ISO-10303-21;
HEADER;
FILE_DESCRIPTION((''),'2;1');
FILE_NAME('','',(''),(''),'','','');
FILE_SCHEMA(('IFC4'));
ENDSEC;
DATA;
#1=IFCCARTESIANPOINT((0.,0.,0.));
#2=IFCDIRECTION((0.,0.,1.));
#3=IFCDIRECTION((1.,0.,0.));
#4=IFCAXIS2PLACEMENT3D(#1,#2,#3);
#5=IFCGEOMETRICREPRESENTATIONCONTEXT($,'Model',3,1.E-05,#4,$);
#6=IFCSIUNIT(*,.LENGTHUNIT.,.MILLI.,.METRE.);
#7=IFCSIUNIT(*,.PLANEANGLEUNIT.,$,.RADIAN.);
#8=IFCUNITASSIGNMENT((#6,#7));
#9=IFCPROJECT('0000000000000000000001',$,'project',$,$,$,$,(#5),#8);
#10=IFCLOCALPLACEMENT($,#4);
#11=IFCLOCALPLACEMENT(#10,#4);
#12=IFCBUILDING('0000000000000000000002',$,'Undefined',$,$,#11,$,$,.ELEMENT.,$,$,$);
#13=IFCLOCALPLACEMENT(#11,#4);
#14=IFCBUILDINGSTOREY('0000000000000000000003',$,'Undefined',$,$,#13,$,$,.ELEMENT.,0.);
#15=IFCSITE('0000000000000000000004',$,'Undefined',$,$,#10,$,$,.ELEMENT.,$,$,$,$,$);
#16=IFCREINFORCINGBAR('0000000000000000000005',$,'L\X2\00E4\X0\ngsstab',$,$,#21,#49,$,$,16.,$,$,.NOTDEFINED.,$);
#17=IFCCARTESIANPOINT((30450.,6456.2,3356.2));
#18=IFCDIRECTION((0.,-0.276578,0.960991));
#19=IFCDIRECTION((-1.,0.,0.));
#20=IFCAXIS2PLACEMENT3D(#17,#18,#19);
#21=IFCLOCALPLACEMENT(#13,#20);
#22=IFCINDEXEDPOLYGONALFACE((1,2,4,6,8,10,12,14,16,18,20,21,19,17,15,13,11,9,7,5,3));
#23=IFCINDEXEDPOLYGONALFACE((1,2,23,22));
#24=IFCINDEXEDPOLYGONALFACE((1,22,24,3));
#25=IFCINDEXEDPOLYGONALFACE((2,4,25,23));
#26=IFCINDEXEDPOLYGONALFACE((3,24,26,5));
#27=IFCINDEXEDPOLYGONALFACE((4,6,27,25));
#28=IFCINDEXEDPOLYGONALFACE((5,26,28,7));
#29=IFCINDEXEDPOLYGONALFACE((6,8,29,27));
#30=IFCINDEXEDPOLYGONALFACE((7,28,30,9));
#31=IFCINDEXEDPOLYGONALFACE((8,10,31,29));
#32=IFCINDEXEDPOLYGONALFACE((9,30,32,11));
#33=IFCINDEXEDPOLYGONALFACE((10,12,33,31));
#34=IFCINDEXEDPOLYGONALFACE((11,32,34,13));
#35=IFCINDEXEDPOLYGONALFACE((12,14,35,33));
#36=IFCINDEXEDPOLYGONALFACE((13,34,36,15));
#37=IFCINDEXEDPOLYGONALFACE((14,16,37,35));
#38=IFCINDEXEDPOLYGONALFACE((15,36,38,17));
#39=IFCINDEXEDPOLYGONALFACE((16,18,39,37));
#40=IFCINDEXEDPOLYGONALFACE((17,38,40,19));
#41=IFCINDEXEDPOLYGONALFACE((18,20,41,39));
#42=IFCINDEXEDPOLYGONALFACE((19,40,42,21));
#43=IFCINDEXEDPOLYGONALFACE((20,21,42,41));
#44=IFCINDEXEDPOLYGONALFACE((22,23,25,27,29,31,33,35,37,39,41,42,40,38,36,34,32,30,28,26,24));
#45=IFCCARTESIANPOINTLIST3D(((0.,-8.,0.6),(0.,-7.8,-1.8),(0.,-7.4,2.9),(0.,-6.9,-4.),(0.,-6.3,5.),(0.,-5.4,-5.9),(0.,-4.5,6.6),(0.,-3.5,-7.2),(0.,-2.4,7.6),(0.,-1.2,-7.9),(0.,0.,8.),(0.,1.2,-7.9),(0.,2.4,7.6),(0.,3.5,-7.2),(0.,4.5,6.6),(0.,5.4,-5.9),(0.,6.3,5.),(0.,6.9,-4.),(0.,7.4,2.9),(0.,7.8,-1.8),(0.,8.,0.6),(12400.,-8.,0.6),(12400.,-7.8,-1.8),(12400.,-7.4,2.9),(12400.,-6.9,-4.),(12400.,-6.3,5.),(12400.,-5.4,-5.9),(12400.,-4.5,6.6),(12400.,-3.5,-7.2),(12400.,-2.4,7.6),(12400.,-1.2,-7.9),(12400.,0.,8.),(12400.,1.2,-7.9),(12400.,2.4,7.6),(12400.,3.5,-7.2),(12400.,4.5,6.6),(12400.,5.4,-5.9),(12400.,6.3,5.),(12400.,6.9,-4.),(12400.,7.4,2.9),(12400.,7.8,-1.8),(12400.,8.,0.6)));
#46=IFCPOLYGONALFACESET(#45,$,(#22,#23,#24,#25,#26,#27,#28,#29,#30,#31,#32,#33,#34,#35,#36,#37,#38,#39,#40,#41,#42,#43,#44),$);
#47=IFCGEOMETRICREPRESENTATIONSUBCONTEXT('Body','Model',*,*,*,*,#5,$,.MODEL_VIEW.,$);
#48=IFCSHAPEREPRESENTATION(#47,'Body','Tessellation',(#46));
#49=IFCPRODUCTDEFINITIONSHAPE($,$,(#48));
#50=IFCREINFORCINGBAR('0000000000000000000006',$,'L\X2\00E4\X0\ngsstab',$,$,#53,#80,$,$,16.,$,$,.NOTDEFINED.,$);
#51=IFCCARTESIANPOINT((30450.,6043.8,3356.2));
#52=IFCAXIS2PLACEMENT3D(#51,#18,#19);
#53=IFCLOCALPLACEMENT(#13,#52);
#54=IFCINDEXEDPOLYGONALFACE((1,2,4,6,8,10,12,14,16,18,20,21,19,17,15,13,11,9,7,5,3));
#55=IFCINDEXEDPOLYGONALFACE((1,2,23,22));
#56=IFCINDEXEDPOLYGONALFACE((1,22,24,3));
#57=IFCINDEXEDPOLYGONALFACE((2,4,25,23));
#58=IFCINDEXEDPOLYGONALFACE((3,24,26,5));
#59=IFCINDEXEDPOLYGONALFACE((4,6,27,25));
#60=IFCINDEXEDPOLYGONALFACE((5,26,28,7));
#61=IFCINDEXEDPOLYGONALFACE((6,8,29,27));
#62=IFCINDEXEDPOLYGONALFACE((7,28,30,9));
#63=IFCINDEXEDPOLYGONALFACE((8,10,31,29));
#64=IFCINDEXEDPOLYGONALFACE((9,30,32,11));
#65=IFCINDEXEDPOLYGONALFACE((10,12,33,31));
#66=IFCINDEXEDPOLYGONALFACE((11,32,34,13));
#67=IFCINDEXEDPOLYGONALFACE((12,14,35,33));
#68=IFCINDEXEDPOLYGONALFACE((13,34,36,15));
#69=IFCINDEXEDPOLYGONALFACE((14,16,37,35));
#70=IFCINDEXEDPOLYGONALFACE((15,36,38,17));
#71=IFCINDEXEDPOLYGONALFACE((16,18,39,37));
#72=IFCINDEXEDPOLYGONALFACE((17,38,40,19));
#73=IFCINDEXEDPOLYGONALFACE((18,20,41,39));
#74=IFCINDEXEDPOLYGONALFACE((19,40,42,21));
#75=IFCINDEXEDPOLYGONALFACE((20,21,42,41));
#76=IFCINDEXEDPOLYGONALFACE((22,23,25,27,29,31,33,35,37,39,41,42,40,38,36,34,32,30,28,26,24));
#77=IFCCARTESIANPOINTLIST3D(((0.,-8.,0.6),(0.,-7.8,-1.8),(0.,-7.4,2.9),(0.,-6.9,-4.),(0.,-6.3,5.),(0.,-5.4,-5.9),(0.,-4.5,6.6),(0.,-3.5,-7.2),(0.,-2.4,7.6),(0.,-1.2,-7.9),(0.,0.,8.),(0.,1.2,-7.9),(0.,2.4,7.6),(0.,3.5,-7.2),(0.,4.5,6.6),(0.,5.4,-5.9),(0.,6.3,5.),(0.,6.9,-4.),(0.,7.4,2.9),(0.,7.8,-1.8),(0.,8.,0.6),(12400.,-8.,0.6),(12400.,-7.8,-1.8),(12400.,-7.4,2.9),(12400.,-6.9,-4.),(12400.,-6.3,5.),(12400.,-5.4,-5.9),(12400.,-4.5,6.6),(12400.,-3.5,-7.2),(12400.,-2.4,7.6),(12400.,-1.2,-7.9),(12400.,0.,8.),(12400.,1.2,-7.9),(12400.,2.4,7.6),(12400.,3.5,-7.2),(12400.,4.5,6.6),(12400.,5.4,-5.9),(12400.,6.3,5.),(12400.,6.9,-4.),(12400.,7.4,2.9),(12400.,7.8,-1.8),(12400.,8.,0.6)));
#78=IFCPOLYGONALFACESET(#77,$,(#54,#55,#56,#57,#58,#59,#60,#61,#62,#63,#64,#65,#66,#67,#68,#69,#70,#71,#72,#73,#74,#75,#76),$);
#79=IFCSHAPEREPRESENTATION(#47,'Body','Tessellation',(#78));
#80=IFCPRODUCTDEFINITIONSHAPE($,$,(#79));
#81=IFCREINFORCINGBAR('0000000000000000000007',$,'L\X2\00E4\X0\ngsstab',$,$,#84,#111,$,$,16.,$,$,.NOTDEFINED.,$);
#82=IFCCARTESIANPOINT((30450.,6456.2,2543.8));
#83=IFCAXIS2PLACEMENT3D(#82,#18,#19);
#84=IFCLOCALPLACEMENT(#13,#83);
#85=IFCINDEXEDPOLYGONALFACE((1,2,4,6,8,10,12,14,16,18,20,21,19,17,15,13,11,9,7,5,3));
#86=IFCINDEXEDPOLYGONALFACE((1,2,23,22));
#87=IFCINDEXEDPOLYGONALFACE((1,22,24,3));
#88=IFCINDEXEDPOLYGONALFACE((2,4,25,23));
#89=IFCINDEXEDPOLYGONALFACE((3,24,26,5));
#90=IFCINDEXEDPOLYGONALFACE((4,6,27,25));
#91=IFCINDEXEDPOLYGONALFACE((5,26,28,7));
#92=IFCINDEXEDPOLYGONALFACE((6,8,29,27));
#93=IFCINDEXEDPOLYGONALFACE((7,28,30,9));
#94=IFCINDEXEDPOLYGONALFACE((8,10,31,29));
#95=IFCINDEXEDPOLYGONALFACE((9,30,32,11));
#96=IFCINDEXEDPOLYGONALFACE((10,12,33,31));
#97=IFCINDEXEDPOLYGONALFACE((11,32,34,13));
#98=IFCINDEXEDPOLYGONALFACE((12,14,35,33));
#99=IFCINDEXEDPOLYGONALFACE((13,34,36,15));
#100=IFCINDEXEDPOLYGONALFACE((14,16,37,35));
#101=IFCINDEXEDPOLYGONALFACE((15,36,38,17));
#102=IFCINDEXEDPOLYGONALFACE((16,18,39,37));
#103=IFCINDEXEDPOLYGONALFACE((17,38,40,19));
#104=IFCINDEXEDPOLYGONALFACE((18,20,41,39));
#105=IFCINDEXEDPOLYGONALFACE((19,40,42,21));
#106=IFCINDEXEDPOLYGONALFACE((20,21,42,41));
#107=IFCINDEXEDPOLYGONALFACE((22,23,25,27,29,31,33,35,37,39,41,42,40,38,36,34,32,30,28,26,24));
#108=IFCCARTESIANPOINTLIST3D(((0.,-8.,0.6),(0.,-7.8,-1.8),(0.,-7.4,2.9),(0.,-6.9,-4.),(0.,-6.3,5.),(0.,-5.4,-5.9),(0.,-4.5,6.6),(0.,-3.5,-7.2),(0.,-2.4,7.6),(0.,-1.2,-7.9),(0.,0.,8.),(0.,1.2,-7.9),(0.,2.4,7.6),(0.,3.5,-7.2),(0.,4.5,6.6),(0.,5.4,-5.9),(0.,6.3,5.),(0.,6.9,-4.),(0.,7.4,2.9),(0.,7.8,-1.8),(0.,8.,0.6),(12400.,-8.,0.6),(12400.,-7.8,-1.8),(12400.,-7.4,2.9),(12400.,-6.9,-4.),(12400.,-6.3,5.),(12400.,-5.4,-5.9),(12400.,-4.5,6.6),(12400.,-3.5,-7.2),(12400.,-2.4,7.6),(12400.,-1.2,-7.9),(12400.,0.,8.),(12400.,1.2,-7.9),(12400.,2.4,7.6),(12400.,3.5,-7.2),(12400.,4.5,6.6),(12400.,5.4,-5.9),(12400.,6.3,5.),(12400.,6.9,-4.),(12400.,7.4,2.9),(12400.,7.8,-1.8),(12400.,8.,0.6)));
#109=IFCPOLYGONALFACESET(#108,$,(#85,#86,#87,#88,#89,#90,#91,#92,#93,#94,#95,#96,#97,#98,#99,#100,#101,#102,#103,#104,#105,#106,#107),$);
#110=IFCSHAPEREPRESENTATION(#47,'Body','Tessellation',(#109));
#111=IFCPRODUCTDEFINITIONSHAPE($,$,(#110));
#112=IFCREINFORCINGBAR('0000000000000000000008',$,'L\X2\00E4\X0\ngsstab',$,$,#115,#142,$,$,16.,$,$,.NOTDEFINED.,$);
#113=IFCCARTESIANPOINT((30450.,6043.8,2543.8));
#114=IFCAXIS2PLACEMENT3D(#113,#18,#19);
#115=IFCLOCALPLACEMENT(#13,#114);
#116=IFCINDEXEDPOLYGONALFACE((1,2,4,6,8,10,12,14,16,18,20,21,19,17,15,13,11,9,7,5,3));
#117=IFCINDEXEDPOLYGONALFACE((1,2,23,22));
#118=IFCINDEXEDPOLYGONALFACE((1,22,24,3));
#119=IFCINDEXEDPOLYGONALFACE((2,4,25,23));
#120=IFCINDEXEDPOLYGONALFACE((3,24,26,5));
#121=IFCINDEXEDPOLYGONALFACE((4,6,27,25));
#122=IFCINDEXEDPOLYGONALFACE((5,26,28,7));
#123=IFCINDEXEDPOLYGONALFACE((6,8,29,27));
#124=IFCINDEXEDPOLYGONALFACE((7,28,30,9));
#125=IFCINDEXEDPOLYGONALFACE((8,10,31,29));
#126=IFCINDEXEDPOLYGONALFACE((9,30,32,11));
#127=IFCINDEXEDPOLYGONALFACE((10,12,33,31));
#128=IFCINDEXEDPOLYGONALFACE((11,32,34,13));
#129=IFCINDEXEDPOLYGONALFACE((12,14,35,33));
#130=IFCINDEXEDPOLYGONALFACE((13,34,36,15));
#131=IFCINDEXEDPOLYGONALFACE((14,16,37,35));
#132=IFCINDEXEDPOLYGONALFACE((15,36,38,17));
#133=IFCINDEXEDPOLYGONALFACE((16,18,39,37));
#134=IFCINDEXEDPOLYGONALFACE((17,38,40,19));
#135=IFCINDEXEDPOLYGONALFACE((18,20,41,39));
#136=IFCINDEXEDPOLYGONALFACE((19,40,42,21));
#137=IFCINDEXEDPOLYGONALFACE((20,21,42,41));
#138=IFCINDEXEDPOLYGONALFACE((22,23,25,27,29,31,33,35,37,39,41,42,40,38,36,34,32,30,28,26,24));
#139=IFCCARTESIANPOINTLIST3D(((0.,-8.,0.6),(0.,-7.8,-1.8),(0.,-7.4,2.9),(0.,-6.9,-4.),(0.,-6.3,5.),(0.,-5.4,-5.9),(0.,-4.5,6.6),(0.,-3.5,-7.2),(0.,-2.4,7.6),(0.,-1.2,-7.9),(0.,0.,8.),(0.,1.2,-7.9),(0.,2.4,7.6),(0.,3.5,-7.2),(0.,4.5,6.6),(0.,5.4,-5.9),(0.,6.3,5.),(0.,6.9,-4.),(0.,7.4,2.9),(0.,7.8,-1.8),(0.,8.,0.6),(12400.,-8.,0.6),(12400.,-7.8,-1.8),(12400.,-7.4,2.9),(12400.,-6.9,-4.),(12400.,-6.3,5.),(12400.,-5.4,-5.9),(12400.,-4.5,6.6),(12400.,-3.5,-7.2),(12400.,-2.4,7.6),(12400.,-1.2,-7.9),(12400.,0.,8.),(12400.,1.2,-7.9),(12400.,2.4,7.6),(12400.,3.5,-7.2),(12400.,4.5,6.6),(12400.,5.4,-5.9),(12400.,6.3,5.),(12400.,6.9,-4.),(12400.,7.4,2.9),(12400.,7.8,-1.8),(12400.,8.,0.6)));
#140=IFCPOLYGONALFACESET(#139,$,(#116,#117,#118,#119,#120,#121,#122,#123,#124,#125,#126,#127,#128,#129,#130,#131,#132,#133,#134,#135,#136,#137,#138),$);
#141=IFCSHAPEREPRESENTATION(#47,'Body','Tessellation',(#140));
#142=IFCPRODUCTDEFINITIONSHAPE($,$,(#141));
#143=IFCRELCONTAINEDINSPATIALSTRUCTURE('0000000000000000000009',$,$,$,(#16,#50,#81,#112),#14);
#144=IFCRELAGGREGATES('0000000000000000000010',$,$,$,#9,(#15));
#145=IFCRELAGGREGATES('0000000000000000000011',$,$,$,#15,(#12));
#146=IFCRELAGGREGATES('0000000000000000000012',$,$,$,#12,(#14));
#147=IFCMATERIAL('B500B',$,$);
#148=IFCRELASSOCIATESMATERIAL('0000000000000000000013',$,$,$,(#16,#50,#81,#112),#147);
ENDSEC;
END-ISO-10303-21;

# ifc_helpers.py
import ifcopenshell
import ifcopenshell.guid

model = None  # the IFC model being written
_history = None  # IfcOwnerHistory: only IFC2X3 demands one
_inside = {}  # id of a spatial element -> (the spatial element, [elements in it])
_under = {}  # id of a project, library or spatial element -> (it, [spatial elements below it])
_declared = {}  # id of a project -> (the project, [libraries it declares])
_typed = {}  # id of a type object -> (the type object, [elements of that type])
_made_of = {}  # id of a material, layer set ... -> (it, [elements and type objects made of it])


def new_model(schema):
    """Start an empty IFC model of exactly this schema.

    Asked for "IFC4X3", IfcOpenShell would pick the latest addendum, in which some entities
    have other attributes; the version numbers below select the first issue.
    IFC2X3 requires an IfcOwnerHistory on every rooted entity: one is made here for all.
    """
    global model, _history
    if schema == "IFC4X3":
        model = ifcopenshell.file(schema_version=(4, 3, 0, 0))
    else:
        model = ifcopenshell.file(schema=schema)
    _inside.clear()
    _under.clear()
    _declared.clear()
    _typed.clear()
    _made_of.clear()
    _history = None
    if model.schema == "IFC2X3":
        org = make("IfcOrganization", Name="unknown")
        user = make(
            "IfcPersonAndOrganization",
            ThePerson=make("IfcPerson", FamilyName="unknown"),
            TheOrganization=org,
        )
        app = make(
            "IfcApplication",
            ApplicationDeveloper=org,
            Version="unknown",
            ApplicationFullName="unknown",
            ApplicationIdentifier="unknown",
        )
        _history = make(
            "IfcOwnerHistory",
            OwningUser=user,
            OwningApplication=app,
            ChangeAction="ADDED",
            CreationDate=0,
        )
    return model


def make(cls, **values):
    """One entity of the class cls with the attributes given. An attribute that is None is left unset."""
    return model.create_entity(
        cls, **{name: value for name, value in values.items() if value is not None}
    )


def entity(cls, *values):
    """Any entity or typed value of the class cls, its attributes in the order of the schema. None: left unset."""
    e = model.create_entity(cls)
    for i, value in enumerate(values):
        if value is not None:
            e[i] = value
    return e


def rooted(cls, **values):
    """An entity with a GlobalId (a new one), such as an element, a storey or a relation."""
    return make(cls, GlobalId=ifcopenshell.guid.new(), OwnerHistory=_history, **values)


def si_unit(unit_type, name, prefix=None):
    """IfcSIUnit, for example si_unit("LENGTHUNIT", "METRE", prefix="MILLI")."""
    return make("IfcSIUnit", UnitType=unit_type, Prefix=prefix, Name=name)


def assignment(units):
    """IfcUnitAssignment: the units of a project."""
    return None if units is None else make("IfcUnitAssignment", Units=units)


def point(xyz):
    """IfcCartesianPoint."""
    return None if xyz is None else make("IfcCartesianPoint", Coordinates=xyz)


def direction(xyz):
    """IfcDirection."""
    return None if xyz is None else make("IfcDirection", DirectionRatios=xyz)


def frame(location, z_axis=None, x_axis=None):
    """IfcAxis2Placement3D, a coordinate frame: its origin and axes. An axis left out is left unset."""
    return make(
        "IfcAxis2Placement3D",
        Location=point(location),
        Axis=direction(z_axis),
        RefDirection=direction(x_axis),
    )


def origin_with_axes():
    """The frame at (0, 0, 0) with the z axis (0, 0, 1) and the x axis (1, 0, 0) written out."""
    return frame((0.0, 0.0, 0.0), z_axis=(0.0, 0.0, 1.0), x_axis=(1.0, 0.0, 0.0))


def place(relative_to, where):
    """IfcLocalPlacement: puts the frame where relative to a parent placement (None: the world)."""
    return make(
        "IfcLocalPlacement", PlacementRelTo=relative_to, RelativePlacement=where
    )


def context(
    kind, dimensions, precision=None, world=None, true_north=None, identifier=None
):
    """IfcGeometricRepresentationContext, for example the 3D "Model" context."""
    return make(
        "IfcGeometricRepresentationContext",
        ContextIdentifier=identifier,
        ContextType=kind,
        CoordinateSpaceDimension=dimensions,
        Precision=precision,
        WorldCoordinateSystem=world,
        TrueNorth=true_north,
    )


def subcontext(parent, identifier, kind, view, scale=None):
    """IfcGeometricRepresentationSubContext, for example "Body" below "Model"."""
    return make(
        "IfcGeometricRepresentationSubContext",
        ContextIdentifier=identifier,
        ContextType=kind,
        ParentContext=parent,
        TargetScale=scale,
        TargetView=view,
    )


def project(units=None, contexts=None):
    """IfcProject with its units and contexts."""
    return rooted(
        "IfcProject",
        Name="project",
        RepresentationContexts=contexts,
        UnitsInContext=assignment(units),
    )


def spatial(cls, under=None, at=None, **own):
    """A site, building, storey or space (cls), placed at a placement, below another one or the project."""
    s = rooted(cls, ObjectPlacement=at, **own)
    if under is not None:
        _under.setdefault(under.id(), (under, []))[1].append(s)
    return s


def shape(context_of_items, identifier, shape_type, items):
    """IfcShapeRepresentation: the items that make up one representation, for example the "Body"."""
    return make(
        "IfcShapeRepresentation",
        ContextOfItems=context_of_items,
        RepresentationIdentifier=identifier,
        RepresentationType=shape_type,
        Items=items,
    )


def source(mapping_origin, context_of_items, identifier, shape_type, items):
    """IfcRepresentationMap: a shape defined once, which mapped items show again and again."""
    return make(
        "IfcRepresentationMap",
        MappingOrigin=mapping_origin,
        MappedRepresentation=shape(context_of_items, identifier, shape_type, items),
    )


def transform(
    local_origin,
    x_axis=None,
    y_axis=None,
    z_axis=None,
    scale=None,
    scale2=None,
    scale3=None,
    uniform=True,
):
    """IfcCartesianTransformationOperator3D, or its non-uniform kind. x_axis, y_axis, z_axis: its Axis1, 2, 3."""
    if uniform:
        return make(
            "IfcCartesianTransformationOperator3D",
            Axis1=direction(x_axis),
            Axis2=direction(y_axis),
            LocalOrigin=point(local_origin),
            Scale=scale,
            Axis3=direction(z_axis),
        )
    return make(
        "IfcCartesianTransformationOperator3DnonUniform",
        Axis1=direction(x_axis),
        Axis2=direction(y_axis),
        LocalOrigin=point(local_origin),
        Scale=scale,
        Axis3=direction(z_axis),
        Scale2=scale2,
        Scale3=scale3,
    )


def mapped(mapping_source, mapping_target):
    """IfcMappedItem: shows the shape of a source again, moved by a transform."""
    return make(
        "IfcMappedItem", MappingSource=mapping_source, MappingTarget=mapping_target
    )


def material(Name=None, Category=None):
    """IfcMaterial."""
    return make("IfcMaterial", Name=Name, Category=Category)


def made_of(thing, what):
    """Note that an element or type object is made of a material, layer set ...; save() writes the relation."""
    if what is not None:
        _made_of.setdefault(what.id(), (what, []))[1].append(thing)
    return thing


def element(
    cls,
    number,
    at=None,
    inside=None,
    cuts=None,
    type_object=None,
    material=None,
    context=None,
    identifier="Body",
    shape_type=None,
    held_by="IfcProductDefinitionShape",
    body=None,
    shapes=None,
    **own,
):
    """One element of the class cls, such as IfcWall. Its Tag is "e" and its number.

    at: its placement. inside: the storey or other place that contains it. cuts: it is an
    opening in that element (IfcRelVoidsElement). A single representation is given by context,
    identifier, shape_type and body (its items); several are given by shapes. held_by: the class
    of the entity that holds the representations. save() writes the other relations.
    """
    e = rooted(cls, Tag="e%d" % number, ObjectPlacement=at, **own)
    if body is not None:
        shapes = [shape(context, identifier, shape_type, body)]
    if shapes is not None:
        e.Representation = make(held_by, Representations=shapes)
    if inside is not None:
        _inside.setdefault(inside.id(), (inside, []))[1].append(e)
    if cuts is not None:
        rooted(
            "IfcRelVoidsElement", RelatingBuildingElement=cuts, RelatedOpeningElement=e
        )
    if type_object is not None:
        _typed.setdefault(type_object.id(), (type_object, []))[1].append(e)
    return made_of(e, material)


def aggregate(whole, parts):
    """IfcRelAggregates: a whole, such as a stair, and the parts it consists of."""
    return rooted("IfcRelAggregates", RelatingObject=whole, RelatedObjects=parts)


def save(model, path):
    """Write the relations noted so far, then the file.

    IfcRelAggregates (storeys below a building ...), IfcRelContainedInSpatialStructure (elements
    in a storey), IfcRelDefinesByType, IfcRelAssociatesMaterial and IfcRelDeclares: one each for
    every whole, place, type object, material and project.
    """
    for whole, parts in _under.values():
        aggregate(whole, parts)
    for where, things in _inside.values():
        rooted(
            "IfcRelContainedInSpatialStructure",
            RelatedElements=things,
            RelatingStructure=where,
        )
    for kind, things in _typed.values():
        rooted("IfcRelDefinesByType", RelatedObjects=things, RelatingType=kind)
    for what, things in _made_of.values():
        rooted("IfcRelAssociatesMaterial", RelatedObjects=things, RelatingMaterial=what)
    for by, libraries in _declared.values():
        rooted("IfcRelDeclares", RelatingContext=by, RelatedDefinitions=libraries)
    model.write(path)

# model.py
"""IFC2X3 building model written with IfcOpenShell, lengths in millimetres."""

from ifc_helpers import new_model, entity, si_unit, frame, origin_with_axes, place, context, subcontext, project, spatial, source, transform, mapped, material, element, save


model = new_model("IFC2X3")

# Units and contexts
model_context = context("Model", 3, precision=1e-05, world=origin_with_axes())
body_context = subcontext(model_context, "Body", "Model", "MODEL_VIEW")
ifc_project = project(units=[si_unit("LENGTHUNIT", "METRE", prefix="MILLI"), si_unit("PLANEANGLEUNIT", "RADIAN")], contexts=[model_context])

# Site, building, storey
site_placement = place(None, origin_with_axes())
site = spatial("IfcSite", under=ifc_project, at=site_placement, Name="Undefined", CompositionType="ELEMENT")
building_placement = place(site_placement, origin_with_axes())
building = spatial("IfcBuilding", under=site, at=building_placement, Name="Undefined", CompositionType="ELEMENT")
storey_placement = place(building_placement, origin_with_axes())
storey = spatial("IfcBuildingStorey", under=building, at=storey_placement, Name="Undefined", CompositionType="ELEMENT", Elevation=0.0)

# Reinforcing bars
ifc_material_1 = material(Name="B500B")
shared_shape_1 = source(origin_with_axes(), body_context, "Body", "AdvancedSweptSolid", [
    entity("IfcSweptDiskSolid", entity("IfcTrimmedCurve", entity("IfcLine", entity("IfcCartesianPoint", [0.0, 0.0, 0.0]), entity("IfcVector", entity("IfcDirection", [1.0, 0.0, 0.0]), 1.0)), [entity("IfcParameterValue", 0.0)], [entity("IfcParameterValue", 12400.0)], True, "PARAMETER"), 8.0, None, 0.0, 12400.0),
])
reinforcing_bar_1_placement = place(storey_placement, frame((30450.0, 6456.2, 3356.2), z_axis=(0.0, -0.276578, 0.960991), x_axis=(-1.0, 0.0, 0.0)))
element("IfcReinforcingBar", 1, at=reinforcing_bar_1_placement, inside=storey, material=ifc_material_1, Name="Längsstab", BarRole="NOTDEFINED", NominalDiameter=16.0, context=body_context, shape_type="MappedRepresentation", body=[
    mapped(shared_shape_1, transform((0.0, 0.0, 0.0))),
])
shared_shape_2 = source(origin_with_axes(), body_context, "Body", "AdvancedSweptSolid", [
    entity("IfcSweptDiskSolid", entity("IfcTrimmedCurve", entity("IfcLine", entity("IfcCartesianPoint", [0.0, 0.0, 0.0]), entity("IfcVector", entity("IfcDirection", [1.0, 0.0, 0.0]), 1.0)), [entity("IfcParameterValue", 0.0)], [entity("IfcParameterValue", 12400.0)], True, "PARAMETER"), 8.0, None, 0.0, 12400.0),
])
reinforcing_bar_2_placement = place(storey_placement, frame((30450.0, 6043.8, 3356.2), z_axis=(0.0, -0.276578, 0.960991), x_axis=(-1.0, 0.0, 0.0)))
element("IfcReinforcingBar", 2, at=reinforcing_bar_2_placement, inside=storey, material=ifc_material_1, Name="Längsstab", BarRole="NOTDEFINED", NominalDiameter=16.0, context=body_context, shape_type="MappedRepresentation", body=[
    mapped(shared_shape_2, transform((0.0, 0.0, 0.0))),
])
shared_shape_3 = source(origin_with_axes(), body_context, "Body", "AdvancedSweptSolid", [
    entity("IfcSweptDiskSolid", entity("IfcTrimmedCurve", entity("IfcLine", entity("IfcCartesianPoint", [0.0, 0.0, 0.0]), entity("IfcVector", entity("IfcDirection", [1.0, 0.0, 0.0]), 1.0)), [entity("IfcParameterValue", 0.0)], [entity("IfcParameterValue", 12400.0)], True, "PARAMETER"), 8.0, None, 0.0, 12400.0),
])
reinforcing_bar_3_placement = place(storey_placement, frame((30450.0, 6456.2, 2543.8), z_axis=(0.0, -0.276578, 0.960991), x_axis=(-1.0, 0.0, 0.0)))
element("IfcReinforcingBar", 3, at=reinforcing_bar_3_placement, inside=storey, material=ifc_material_1, Name="Längsstab", BarRole="NOTDEFINED", NominalDiameter=16.0, context=body_context, shape_type="MappedRepresentation", body=[
    mapped(shared_shape_3, transform((0.0, 0.0, 0.0))),
])
shared_shape_4 = source(origin_with_axes(), body_context, "Body", "AdvancedSweptSolid", [
    entity("IfcSweptDiskSolid", entity("IfcTrimmedCurve", entity("IfcLine", entity("IfcCartesianPoint", [0.0, 0.0, 0.0]), entity("IfcVector", entity("IfcDirection", [1.0, 0.0, 0.0]), 1.0)), [entity("IfcParameterValue", 0.0)], [entity("IfcParameterValue", 12400.0)], True, "PARAMETER"), 8.0, None, 0.0, 12400.0),
])
reinforcing_bar_4_placement = place(storey_placement, frame((30450.0, 6043.8, 2543.8), z_axis=(0.0, -0.276578, 0.960991), x_axis=(-1.0, 0.0, 0.0)))
element("IfcReinforcingBar", 4, at=reinforcing_bar_4_placement, inside=storey, material=ifc_material_1, Name="Längsstab", BarRole="NOTDEFINED", NominalDiameter=16.0, context=body_context, shape_type="MappedRepresentation", body=[
    mapped(shared_shape_4, transform((0.0, 0.0, 0.0))),
])

save(model, "model.ifc")
